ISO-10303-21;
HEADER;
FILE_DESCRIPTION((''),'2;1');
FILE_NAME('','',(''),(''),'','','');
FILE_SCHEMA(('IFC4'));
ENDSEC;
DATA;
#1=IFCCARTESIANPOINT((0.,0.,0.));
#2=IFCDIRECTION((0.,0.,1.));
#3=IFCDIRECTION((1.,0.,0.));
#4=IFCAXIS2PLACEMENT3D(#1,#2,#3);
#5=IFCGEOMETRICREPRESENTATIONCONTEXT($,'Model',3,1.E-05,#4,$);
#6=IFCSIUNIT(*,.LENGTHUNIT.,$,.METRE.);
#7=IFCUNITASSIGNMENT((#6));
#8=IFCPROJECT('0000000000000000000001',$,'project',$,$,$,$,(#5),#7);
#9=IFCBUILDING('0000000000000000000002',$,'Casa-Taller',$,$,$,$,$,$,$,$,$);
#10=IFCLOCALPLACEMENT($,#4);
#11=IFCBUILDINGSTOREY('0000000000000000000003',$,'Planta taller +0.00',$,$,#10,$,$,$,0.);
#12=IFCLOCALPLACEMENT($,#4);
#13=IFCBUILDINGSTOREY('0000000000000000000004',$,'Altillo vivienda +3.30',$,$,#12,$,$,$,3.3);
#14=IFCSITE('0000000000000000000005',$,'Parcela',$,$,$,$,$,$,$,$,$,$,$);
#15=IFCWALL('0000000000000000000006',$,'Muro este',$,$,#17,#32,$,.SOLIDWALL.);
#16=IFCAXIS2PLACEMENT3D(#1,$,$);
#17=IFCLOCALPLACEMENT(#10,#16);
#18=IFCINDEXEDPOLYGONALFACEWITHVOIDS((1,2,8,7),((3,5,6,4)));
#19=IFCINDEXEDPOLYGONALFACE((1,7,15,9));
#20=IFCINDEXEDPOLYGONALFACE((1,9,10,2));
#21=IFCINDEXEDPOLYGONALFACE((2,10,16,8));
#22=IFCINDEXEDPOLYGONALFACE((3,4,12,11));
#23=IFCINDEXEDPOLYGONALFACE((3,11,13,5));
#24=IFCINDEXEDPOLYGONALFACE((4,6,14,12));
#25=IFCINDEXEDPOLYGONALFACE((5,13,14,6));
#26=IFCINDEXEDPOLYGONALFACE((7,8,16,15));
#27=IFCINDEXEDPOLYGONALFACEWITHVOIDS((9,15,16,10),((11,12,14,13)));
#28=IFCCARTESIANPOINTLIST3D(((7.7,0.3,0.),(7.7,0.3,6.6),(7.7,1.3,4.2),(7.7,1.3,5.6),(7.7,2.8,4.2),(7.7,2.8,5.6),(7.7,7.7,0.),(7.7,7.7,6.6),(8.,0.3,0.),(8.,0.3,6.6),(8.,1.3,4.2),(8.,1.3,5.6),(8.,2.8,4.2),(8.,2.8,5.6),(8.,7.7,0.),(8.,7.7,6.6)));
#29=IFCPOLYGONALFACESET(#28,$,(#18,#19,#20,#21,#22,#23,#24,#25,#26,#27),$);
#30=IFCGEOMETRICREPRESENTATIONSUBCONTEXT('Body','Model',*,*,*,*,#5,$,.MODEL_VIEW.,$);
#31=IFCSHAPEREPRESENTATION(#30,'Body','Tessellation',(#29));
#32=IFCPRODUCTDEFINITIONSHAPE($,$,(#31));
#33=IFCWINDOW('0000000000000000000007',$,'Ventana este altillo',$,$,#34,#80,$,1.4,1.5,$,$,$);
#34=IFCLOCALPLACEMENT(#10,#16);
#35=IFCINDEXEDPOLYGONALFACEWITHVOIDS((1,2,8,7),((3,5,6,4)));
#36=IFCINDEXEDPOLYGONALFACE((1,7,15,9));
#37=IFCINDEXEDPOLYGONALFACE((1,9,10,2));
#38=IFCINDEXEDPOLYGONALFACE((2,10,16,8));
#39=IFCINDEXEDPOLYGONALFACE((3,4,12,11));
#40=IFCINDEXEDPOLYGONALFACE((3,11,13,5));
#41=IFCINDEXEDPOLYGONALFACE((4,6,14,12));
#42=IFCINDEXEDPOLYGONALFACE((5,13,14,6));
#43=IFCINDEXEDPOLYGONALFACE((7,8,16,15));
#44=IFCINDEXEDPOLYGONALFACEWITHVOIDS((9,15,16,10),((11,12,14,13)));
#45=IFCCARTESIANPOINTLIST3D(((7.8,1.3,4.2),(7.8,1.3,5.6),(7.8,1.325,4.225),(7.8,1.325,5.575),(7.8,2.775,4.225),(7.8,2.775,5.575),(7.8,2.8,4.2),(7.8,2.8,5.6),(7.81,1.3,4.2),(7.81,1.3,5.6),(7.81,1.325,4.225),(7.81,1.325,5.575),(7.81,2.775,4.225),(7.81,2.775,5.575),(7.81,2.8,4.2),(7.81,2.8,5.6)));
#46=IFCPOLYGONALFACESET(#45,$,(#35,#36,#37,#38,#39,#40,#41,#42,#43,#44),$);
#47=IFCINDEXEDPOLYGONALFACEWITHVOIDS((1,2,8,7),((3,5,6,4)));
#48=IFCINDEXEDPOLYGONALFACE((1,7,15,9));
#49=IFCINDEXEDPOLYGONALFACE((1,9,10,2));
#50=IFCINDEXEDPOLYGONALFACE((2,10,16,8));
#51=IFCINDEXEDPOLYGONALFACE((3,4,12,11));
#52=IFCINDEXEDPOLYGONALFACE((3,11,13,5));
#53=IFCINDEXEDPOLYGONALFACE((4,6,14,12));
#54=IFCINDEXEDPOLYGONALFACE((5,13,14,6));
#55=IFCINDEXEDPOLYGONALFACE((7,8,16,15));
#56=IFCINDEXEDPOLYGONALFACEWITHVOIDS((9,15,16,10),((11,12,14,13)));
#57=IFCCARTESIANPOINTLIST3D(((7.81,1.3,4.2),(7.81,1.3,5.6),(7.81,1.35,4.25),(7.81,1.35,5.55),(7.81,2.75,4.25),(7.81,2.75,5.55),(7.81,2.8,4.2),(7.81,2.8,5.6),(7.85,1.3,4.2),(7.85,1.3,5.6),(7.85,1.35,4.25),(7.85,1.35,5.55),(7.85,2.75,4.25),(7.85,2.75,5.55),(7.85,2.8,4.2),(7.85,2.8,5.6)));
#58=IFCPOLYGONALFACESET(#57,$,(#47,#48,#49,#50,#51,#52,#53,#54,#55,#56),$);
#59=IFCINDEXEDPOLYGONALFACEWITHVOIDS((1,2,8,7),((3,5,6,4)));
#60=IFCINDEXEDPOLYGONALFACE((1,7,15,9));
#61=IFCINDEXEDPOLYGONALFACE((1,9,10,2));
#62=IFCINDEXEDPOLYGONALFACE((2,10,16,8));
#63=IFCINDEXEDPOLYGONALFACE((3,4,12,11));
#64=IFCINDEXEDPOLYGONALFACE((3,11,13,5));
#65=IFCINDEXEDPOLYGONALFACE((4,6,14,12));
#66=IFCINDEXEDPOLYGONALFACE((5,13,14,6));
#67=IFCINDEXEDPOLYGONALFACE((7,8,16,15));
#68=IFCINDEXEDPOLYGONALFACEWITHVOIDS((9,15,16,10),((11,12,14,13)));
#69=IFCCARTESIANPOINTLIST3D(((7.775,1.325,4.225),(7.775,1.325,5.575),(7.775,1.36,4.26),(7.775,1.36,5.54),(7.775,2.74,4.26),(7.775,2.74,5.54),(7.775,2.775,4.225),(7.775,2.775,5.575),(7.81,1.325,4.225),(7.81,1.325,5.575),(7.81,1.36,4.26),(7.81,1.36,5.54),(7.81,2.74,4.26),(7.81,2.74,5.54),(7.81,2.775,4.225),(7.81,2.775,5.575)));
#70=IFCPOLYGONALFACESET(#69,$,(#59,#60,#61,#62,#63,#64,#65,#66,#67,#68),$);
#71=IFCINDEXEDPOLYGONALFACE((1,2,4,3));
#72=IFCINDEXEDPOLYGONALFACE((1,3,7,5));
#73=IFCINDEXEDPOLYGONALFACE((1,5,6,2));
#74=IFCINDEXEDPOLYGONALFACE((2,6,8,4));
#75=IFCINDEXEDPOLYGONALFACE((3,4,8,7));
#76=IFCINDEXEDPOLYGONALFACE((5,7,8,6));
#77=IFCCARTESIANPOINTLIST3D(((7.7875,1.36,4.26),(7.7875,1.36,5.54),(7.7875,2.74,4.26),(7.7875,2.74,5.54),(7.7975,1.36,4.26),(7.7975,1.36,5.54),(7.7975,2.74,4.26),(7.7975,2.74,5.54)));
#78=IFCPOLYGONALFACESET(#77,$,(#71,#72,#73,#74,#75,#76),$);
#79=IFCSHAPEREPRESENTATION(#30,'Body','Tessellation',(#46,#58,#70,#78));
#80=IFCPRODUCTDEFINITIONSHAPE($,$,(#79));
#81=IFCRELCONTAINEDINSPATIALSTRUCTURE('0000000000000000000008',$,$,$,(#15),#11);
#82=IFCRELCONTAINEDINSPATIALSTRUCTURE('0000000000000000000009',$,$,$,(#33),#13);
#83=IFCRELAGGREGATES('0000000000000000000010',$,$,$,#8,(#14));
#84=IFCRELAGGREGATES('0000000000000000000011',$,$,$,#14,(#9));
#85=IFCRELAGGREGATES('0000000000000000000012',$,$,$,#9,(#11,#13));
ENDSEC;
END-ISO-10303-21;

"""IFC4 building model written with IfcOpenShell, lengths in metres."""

from ifc_helpers import new_model, si_unit, frame, origin_with_axes, place, context, subcontext, project, spatial, line, indexed_curve, outline, extrude, element, fill, save


model = new_model("IFC4")

# Units and contexts
model_context = context("Model", 3, precision=1e-05, world=origin_with_axes())
body_context = subcontext(model_context, "Body", "Model", "MODEL_VIEW")
ifc_project = project(units=[si_unit("LENGTHUNIT", "METRE")], contexts=[model_context])

# Site, building, storey
site = spatial("IfcSite", under=ifc_project, Name="Parcela")
building = spatial("IfcBuilding", under=site, Name="Casa-Taller")
storey_1_placement = place(None, origin_with_axes())
storey_1 = spatial("IfcBuildingStorey", under=building, at=storey_1_placement, Name="Planta taller +0.00", Elevation=0.0)

# Shared definitions
storey_2_placement = place(None, origin_with_axes())
storey_2 = spatial("IfcBuildingStorey", under=building, at=storey_2_placement, Name="Altillo vivienda +3.30", Elevation=3.3)

# Wall, opening, window
wall_1_placement = place(storey_1_placement, frame((8.0, 0.3, 0.0), z_axis=(0.0, 0.0, 1.0), x_axis=(0.0, 1.0, 0.0)))
wall_1 = element("IfcWall", 1, at=wall_1_placement, inside=storey_1, Name="Muro este", PredefinedType="SOLIDWALL", context=body_context, shape_type="SweptSolid", body=[
    extrude(outline(indexed_curve([(0.0, 0.0), (0.0, 0.3), (7.4, 0.3), (7.4, 0.0), (0.0, 0.0)], self_intersect=False)), origin_with_axes(), (0.0, 0.0, 1.0), 6.6),
])
opening_1_placement = place(wall_1_placement, frame((1.0, -0.1, 4.2), z_axis=(0.0, 0.0, 1.0), x_axis=(1.0, 0.0, 0.0)))
opening_1 = element("IfcOpeningElement", 2, at=opening_1_placement, cuts=wall_1, context=body_context, shape_type="SweptSolid", body=[
    extrude(outline(indexed_curve([(0.0, 0.0), (0.0, 0.5), (1.5, 0.5), (1.5, 0.0), (0.0, 0.0)], self_intersect=False)), origin_with_axes(), (0.0, 0.0, 1.0), 1.4),
])
window_1_placement = place(opening_1_placement, frame((0.0, 0.2, 0.0), z_axis=(0.0, 0.0, 1.0), x_axis=(1.0, 0.0, 0.0)))
window_1 = element("IfcWindow", 3, at=window_1_placement, inside=storey_2, Name="Ventana este altillo", OverallHeight=1.4, OverallWidth=1.5, context=body_context, shape_type="SweptSolid", body=[
    extrude(outline(indexed_curve([(0.0, 0.0), (1.5, 0.0), (1.5, 1.4), (0.0, 1.4)], segments=[line(1, 2, 3, 4, 1)]), holes=[indexed_curve([(0.025, 0.025), (1.475, 0.025), (1.475, 1.375), (0.025, 1.375)], segments=[line(1, 2, 3, 4, 1)])]), frame((0.0, 0.09, 0.0), z_axis=(0.0, -1.0, 0.0), x_axis=(1.0, 0.0, 0.0)), (0.0, 0.0, -1.0), 0.01),
    extrude(outline(indexed_curve([(0.0, 0.0), (1.5, 0.0), (1.5, 1.4), (0.0, 1.4)], segments=[line(1, 2, 3, 4, 1)]), holes=[indexed_curve([(0.05, 0.05), (1.45, 0.05), (1.45, 1.35), (0.05, 1.35)], segments=[line(1, 2, 3, 4, 1)])]), frame((0.0, 0.05, 0.0), z_axis=(0.0, -1.0, 0.0), x_axis=(1.0, 0.0, 0.0)), (0.0, 0.0, -1.0), 0.04),
    extrude(outline(indexed_curve([(0.0, 0.0), (1.45, 0.0), (1.45, 1.35), (0.0, 1.35)], segments=[line(1, 2, 3, 4, 1)]), holes=[indexed_curve([(0.035, 0.035), (1.415, 0.035), (1.415, 1.315), (0.035, 1.315)], segments=[line(1, 2, 3, 4, 1)])]), frame((0.025, 0.09, 0.025), z_axis=(0.0, -1.0, 0.0), x_axis=(1.0, 0.0, 0.0)), (0.0, 0.0, -1.0), 0.035),
    extrude(outline(indexed_curve([(0.035, 0.035), (1.415, 0.035), (1.415, 1.315), (0.035, 1.315)], segments=[line(1, 2, 3, 4, 1)])), frame((0.025, 0.1025, 0.025), z_axis=(0.0, -1.0, 0.0), x_axis=(1.0, 0.0, 0.0)), (0.0, 0.0, -1.0), 0.01),
])
fill(opening_1, window_1)

save(model, "model.ifc")
